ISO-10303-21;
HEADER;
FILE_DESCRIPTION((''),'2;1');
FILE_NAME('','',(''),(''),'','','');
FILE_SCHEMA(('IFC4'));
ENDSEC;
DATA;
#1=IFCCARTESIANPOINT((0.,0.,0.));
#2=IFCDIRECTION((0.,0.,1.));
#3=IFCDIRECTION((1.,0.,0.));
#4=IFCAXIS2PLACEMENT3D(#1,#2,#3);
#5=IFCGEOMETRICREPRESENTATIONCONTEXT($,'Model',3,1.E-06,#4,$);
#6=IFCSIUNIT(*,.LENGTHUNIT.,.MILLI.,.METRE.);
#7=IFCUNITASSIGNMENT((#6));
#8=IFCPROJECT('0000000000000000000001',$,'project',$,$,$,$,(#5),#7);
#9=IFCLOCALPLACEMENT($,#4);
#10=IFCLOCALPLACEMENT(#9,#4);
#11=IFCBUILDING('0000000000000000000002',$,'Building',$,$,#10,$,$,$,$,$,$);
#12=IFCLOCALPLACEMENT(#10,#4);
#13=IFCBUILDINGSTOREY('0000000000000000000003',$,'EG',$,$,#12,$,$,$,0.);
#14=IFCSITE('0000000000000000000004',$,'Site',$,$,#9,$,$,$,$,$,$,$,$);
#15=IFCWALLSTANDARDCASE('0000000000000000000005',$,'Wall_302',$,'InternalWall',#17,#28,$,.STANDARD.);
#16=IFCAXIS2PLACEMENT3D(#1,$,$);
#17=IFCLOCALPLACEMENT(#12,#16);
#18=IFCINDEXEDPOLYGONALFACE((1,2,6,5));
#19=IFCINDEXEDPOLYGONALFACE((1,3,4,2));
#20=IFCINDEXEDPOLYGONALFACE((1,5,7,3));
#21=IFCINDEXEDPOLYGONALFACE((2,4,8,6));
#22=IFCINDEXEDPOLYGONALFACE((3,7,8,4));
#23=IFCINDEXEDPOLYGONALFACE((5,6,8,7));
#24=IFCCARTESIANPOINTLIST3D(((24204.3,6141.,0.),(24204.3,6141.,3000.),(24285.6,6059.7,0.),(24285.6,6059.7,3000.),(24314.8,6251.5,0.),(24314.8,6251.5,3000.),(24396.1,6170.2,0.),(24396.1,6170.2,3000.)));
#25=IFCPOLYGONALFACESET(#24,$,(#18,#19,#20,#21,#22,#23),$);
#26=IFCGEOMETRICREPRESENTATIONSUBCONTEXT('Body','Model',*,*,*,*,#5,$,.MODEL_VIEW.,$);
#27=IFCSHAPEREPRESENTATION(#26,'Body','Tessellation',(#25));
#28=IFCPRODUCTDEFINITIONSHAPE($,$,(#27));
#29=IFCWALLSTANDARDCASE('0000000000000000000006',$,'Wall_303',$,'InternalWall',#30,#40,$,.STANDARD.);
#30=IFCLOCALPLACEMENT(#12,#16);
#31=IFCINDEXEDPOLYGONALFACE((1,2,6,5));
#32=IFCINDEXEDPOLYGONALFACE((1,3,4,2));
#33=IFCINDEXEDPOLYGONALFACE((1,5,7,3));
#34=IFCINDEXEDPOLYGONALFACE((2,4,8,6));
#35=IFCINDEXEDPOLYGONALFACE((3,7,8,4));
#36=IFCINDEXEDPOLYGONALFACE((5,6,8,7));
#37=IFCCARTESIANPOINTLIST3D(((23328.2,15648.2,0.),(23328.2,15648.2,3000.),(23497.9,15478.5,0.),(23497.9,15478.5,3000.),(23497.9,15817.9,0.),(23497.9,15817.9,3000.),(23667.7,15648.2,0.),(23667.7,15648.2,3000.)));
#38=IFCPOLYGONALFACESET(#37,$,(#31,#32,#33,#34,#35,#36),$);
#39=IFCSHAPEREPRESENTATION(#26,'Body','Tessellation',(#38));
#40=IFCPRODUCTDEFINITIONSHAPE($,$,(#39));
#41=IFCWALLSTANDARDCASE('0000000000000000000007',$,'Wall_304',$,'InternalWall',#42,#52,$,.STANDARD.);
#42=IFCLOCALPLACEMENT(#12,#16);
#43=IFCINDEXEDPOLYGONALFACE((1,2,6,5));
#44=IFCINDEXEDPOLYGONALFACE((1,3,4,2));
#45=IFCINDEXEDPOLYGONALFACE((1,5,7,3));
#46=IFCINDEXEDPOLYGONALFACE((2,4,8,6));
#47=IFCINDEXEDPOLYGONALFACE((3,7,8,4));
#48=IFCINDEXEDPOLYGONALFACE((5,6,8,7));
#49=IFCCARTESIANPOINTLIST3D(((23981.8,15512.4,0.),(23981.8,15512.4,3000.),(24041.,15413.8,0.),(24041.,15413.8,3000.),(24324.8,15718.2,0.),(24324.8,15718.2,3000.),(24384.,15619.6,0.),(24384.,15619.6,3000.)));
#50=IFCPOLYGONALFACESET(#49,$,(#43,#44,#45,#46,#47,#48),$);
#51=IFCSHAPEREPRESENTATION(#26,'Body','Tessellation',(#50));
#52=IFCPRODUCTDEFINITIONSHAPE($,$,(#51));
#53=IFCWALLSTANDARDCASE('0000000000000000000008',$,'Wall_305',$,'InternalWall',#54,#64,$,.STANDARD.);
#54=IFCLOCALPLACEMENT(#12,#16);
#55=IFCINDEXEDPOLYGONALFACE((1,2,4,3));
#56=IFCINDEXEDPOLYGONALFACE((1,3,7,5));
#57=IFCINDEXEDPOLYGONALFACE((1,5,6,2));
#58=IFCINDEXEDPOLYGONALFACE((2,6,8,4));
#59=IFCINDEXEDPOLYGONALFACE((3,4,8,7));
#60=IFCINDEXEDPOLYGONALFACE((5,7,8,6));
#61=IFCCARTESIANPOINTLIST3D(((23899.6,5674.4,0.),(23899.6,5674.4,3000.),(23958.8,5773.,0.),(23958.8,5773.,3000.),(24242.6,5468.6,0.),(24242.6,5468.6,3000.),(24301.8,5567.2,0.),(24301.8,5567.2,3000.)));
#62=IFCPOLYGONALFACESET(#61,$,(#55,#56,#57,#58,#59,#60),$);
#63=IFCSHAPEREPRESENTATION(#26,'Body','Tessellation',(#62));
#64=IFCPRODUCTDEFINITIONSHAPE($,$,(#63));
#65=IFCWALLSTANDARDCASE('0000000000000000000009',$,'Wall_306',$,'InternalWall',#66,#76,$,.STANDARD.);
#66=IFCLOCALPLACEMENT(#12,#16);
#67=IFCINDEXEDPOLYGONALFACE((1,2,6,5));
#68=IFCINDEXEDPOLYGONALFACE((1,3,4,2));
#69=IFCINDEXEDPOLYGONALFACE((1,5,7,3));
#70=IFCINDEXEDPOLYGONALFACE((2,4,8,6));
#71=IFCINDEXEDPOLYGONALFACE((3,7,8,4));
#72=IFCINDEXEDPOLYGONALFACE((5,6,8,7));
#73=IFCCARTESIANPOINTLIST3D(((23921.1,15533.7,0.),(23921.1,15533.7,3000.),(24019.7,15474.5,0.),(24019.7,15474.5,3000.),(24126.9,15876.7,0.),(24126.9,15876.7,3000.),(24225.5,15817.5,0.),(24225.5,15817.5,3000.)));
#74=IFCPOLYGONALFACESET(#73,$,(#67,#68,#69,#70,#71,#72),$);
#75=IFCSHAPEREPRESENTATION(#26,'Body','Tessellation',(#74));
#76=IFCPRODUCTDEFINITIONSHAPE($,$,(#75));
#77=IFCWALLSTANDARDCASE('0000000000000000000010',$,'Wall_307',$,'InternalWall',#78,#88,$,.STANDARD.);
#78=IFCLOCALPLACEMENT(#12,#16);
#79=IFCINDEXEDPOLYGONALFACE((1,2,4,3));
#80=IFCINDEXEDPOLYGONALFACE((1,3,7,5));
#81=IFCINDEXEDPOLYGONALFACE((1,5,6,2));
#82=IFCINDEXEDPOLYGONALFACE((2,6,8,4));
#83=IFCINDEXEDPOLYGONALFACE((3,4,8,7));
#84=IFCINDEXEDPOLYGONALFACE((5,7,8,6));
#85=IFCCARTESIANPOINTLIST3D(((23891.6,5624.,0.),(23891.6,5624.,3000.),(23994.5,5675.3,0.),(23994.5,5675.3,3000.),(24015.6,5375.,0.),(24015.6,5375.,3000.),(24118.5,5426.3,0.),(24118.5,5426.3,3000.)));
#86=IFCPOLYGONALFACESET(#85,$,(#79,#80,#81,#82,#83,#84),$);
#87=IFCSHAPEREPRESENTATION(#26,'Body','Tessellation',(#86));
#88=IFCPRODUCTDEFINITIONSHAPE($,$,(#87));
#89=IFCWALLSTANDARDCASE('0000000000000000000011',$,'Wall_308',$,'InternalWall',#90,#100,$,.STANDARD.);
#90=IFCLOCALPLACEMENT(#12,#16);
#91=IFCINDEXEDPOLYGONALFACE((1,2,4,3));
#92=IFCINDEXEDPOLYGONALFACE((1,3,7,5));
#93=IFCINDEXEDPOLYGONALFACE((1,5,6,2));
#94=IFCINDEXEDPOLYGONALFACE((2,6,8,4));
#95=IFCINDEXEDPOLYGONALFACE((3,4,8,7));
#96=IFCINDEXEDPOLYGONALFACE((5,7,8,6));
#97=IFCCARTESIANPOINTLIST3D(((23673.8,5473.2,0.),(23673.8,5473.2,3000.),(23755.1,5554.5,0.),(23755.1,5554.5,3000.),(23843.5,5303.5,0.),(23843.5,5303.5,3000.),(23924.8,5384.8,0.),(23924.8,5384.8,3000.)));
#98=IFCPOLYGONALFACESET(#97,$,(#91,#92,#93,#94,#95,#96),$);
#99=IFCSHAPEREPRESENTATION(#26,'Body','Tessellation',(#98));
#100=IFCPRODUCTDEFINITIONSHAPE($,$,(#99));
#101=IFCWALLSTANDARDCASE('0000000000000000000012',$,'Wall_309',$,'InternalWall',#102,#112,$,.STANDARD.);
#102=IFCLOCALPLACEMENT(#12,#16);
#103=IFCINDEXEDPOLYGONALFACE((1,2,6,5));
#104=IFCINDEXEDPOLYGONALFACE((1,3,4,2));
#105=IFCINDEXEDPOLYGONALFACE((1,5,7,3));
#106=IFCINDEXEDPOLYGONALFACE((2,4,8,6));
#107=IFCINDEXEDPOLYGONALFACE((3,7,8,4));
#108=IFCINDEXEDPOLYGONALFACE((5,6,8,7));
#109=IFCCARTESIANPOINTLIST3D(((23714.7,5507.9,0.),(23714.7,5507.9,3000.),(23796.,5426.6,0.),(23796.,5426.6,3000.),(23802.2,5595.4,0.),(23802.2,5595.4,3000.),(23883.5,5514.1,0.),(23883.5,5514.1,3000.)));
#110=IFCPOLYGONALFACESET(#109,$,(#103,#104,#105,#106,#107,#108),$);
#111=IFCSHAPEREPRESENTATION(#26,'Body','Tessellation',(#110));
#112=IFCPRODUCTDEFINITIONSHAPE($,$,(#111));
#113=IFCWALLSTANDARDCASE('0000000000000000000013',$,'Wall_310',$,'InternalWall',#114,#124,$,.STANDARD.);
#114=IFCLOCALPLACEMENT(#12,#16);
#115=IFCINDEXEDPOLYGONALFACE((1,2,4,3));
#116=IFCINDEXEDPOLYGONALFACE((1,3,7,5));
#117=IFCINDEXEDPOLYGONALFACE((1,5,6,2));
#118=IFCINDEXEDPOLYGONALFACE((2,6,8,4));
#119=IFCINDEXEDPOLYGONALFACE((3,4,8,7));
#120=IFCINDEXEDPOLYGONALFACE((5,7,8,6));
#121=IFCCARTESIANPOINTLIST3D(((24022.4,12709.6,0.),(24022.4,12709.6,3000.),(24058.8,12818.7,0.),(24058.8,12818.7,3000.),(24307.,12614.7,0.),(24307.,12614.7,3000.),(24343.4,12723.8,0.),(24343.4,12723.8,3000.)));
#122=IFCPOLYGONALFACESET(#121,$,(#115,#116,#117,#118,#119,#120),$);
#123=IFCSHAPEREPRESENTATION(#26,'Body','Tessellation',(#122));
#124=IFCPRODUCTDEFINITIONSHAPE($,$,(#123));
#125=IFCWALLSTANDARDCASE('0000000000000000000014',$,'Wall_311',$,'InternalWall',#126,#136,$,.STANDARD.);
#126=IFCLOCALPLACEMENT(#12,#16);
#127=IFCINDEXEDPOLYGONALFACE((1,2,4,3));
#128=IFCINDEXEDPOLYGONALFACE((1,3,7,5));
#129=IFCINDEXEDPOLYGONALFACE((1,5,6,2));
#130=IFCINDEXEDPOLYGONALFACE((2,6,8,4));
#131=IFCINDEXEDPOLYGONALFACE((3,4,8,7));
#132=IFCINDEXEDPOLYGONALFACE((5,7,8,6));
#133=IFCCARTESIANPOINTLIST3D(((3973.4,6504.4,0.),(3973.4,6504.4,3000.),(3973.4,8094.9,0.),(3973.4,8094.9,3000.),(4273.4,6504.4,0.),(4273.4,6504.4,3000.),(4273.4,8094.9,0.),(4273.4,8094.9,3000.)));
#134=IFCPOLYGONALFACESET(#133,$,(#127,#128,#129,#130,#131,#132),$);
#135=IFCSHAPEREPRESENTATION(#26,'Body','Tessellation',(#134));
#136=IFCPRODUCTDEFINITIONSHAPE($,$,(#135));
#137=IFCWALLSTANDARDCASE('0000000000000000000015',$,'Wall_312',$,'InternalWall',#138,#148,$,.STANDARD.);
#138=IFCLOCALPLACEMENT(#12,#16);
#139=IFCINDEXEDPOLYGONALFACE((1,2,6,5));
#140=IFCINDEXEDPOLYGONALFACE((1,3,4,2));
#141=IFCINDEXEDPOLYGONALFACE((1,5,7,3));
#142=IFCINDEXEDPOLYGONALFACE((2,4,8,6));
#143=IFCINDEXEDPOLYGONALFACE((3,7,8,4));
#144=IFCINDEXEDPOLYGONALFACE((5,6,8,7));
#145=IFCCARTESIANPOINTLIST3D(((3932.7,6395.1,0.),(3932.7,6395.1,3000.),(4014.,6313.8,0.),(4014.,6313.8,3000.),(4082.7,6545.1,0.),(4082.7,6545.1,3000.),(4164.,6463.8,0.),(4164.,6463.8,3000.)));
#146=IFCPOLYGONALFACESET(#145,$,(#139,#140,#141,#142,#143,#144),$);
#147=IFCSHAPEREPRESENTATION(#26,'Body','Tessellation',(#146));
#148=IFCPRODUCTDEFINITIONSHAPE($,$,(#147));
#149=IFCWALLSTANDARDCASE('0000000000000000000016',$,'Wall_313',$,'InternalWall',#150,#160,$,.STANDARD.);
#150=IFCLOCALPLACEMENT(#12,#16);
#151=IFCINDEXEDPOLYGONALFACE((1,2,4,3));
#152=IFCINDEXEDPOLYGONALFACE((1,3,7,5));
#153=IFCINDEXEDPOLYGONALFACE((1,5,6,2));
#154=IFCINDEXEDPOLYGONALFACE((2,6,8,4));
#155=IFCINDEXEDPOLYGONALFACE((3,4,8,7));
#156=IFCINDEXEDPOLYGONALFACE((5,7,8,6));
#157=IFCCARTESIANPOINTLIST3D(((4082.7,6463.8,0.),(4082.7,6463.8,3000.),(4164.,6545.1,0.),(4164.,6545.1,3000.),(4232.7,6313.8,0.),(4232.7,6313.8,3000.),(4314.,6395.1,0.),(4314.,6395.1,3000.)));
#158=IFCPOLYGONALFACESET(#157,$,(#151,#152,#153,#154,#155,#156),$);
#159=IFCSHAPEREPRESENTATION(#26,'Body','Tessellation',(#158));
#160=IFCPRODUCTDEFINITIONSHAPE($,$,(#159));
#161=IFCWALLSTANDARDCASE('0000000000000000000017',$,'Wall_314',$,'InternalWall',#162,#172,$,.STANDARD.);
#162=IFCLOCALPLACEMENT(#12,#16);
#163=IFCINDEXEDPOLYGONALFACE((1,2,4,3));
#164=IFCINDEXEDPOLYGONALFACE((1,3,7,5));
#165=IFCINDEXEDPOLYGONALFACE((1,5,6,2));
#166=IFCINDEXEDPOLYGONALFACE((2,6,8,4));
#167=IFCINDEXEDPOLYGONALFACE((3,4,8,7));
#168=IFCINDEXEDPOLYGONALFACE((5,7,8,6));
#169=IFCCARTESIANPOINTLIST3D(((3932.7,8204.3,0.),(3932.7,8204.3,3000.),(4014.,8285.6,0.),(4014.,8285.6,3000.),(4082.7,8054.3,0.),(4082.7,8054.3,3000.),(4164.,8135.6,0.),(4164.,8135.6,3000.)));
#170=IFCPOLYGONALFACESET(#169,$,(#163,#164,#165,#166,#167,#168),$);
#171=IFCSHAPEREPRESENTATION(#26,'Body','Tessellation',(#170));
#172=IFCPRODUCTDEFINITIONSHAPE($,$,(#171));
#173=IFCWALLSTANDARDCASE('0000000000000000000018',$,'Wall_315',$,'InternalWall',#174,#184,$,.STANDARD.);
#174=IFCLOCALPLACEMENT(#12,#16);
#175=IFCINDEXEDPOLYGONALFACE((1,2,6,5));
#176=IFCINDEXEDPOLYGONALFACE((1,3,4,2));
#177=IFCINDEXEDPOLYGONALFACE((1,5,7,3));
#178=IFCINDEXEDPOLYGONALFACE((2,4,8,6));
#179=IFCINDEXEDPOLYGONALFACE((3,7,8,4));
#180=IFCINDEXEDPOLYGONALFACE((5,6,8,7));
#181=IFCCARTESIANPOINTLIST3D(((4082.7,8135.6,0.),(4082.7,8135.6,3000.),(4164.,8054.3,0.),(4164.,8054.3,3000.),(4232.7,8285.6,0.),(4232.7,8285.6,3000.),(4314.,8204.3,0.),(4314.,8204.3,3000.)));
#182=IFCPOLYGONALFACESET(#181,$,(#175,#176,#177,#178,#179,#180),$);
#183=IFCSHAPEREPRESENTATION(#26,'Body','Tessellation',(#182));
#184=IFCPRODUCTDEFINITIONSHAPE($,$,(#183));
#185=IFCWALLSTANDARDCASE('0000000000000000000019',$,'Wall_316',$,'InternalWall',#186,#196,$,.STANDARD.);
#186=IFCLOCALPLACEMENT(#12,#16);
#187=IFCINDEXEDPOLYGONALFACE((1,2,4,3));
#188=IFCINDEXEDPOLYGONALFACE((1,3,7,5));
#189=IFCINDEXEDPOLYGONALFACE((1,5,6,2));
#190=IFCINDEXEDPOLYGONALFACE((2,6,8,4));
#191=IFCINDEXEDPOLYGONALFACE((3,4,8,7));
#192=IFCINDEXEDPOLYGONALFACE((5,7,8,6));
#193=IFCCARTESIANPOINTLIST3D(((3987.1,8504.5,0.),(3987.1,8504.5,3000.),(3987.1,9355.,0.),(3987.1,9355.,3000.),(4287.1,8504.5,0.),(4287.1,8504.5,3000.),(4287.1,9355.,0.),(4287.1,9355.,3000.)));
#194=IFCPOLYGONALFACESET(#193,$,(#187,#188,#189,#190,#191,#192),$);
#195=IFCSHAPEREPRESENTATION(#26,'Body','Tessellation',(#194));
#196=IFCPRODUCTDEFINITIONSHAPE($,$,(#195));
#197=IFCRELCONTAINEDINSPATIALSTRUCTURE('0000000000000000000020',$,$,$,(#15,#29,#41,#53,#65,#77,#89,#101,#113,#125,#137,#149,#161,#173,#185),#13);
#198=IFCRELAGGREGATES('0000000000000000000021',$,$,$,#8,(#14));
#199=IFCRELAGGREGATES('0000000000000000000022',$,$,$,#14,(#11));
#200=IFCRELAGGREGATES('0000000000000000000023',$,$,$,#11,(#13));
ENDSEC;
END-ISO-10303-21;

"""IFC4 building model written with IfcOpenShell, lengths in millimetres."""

from ifc_helpers import new_model, si_unit, frame, origin_with_axes, place, context, subcontext, project, spatial, rectangle, extrude, element, save


model = new_model("IFC4")

# Units and contexts
model_context = context("Model", 3, precision=1e-06, world=origin_with_axes())
body_context = subcontext(model_context, "Body", "Model", "MODEL_VIEW")
ifc_project = project(units=[si_unit("LENGTHUNIT", "METRE", prefix="MILLI")], contexts=[model_context])

# Site, building, storey
site_placement = place(None, origin_with_axes())
site = spatial("IfcSite", under=ifc_project, at=site_placement, Name="Site")
building_placement = place(site_placement, origin_with_axes())
building = spatial("IfcBuilding", under=site, at=building_placement, Name="Building")
storey_placement = place(building_placement, origin_with_axes())
storey = spatial("IfcBuildingStorey", under=building, at=storey_placement, Name="EG", Elevation=0.0)

# Walls
wall_1_placement = place(storey_placement, origin_with_axes())
element("IfcWallStandardCase", 1, at=wall_1_placement, inside=storey, Name="Wall_302", ObjectType="InternalWall", PredefinedType="STANDARD", context=body_context, shape_type="SweptSolid", body=[
    extrude(rectangle(XDim=156.3, YDim=115.0), frame((24300.2, 6155.6, 0.0), z_axis=(0.0, 0.0, 1.0), x_axis=(0.707107, 0.707107, 0.0)), (0.0, 0.0, 1.0), 3000.0),
])
wall_2_placement = place(storey_placement, origin_with_axes())
element("IfcWallStandardCase", 2, at=wall_2_placement, inside=storey, Name="Wall_303", ObjectType="InternalWall", PredefinedType="STANDARD", context=body_context, shape_type="SweptSolid", body=[
    extrude(rectangle(XDim=240.0, YDim=240.0), frame((23497.9, 15648.2, 0.0), z_axis=(0.0, 0.0, 1.0), x_axis=(0.707107, -0.707107, 0.0)), (0.0, 0.0, 1.0), 3000.0),
])
wall_3_placement = place(storey_placement, origin_with_axes())
element("IfcWallStandardCase", 3, at=wall_3_placement, inside=storey, Name="Wall_304", ObjectType="InternalWall", PredefinedType="STANDARD", context=body_context, shape_type="SweptSolid", body=[
    extrude(rectangle(XDim=400.0, YDim=115.0), frame((24182.9, 15566.0, 0.0), z_axis=(0.0, 0.0, 1.0), x_axis=(0.857493, 0.514496, 0.0)), (0.0, 0.0, 1.0), 3000.0),
])
wall_4_placement = place(storey_placement, origin_with_axes())
element("IfcWallStandardCase", 4, at=wall_4_placement, inside=storey, Name="Wall_305", ObjectType="InternalWall", PredefinedType="STANDARD", context=body_context, shape_type="SweptSolid", body=[
    extrude(rectangle(XDim=400.0, YDim=115.0), frame((24100.7, 5620.8, 0.0), z_axis=(0.0, 0.0, 1.0), x_axis=(-0.857493, 0.514496, 0.0)), (0.0, 0.0, 1.0), 3000.0),
])
wall_5_placement = place(storey_placement, origin_with_axes())
element("IfcWallStandardCase", 5, at=wall_5_placement, inside=storey, Name="Wall_306", ObjectType="InternalWall", PredefinedType="STANDARD", context=body_context, shape_type="SweptSolid", body=[
    extrude(rectangle(XDim=400.0, YDim=115.0), frame((24073.3, 15675.6, 0.0), z_axis=(0.0, 0.0, 1.0), x_axis=(-0.514496, -0.857493, 0.0)), (0.0, 0.0, 1.0), 3000.0),
])
wall_6_placement = place(storey_placement, origin_with_axes())
element("IfcWallStandardCase", 6, at=wall_6_placement, inside=storey, Name="Wall_307", ObjectType="InternalWall", PredefinedType="STANDARD", context=body_context, shape_type="SweptSolid", body=[
    extrude(rectangle(XDim=278.2, YDim=115.0), frame((24005.1, 5525.1, 0.0), z_axis=(0.0, 0.0, 1.0), x_axis=(0.445775, -0.895145, 0.0)), (0.0, 0.0, 1.0), 3000.0),
])
wall_7_placement = place(storey_placement, origin_with_axes())
element("IfcWallStandardCase", 7, at=wall_7_placement, inside=storey, Name="Wall_308", ObjectType="InternalWall", PredefinedType="STANDARD", context=body_context, shape_type="SweptSolid", body=[
    extrude(rectangle(XDim=240.0, YDim=115.0), frame((23799.3, 5429.0, 0.0), z_axis=(0.0, 0.0, 1.0), x_axis=(-0.707107, 0.707107, 0.0)), (0.0, 0.0, 1.0), 3000.0),
])
wall_8_placement = place(storey_placement, origin_with_axes())
element("IfcWallStandardCase", 8, at=wall_8_placement, inside=storey, Name="Wall_309", ObjectType="InternalWall", PredefinedType="STANDARD", context=body_context, shape_type="SweptSolid", body=[
    extrude(rectangle(XDim=123.7, YDim=115.0), frame((23799.1, 5511.0, 0.0), z_axis=(0.0, 0.0, 1.0), x_axis=(-0.707107, -0.707107, 0.0)), (0.0, 0.0, 1.0), 3000.0),
])
wall_9_placement = place(storey_placement, origin_with_axes())
element("IfcWallStandardCase", 9, at=wall_9_placement, inside=storey, Name="Wall_310", ObjectType="InternalWall", PredefinedType="STANDARD", context=body_context, shape_type="SweptSolid", body=[
    extrude(rectangle(XDim=300.0, YDim=115.0), frame((24182.9, 12716.7, 0.0), z_axis=(0.0, 0.0, 1.0), x_axis=(-0.948683, 0.316228, 0.0)), (0.0, 0.0, 1.0), 3000.0),
])
wall_10_placement = place(storey_placement, origin_with_axes())
element("IfcWallStandardCase", 10, at=wall_10_placement, inside=storey, Name="Wall_311", ObjectType="InternalWall", PredefinedType="STANDARD", context=body_context, shape_type="SweptSolid", body=[
    extrude(rectangle(XDim=1590.5, YDim=300.0), frame((4123.4, 7299.7, 0.0), z_axis=(0.0, 0.0, 1.0), x_axis=(0.0, -1.0, 0.0)), (0.0, 0.0, 1.0), 3000.0),
])
wall_11_placement = place(storey_placement, origin_with_axes())
element("IfcWallStandardCase", 11, at=wall_11_placement, inside=storey, Name="Wall_312", ObjectType="InternalWall", PredefinedType="STANDARD", context=body_context, shape_type="SweptSolid", body=[
    extrude(rectangle(XDim=212.1, YDim=115.0), frame((4048.4, 6429.4, 0.0), z_axis=(0.0, 0.0, 1.0), x_axis=(-0.707107, -0.707107, 0.0)), (0.0, 0.0, 1.0), 3000.0),
])
wall_12_placement = place(storey_placement, origin_with_axes())
element("IfcWallStandardCase", 12, at=wall_12_placement, inside=storey, Name="Wall_313", ObjectType="InternalWall", PredefinedType="STANDARD", context=body_context, shape_type="SweptSolid", body=[
    extrude(rectangle(XDim=212.1, YDim=115.0), frame((4198.4, 6429.4, 0.0), z_axis=(0.0, 0.0, 1.0), x_axis=(0.707107, -0.707107, 0.0)), (0.0, 0.0, 1.0), 3000.0),
])
wall_13_placement = place(storey_placement, origin_with_axes())
element("IfcWallStandardCase", 13, at=wall_13_placement, inside=storey, Name="Wall_314", ObjectType="InternalWall", PredefinedType="STANDARD", context=body_context, shape_type="SweptSolid", body=[
    extrude(rectangle(XDim=212.1, YDim=115.0), frame((4048.4, 8169.9, 0.0), z_axis=(0.0, 0.0, 1.0), x_axis=(-0.707107, 0.707107, 0.0)), (0.0, 0.0, 1.0), 3000.0),
])
wall_14_placement = place(storey_placement, origin_with_axes())
element("IfcWallStandardCase", 14, at=wall_14_placement, inside=storey, Name="Wall_315", ObjectType="InternalWall", PredefinedType="STANDARD", context=body_context, shape_type="SweptSolid", body=[
    extrude(rectangle(XDim=212.1, YDim=115.0), frame((4198.4, 8169.9, 0.0), z_axis=(0.0, 0.0, 1.0), x_axis=(0.707107, 0.707107, 0.0)), (0.0, 0.0, 1.0), 3000.0),
])
wall_15_placement = place(storey_placement, origin_with_axes())
element("IfcWallStandardCase", 15, at=wall_15_placement, inside=storey, Name="Wall_316", ObjectType="InternalWall", PredefinedType="STANDARD", context=body_context, shape_type="SweptSolid", body=[
    extrude(rectangle(XDim=850.5, YDim=300.0), frame((4137.1, 8929.8, 0.0), z_axis=(0.0, 0.0, 1.0), x_axis=(0.0, 1.0, 0.0)), (0.0, 0.0, 1.0), 3000.0),
])

save(model, "model.ifc")
